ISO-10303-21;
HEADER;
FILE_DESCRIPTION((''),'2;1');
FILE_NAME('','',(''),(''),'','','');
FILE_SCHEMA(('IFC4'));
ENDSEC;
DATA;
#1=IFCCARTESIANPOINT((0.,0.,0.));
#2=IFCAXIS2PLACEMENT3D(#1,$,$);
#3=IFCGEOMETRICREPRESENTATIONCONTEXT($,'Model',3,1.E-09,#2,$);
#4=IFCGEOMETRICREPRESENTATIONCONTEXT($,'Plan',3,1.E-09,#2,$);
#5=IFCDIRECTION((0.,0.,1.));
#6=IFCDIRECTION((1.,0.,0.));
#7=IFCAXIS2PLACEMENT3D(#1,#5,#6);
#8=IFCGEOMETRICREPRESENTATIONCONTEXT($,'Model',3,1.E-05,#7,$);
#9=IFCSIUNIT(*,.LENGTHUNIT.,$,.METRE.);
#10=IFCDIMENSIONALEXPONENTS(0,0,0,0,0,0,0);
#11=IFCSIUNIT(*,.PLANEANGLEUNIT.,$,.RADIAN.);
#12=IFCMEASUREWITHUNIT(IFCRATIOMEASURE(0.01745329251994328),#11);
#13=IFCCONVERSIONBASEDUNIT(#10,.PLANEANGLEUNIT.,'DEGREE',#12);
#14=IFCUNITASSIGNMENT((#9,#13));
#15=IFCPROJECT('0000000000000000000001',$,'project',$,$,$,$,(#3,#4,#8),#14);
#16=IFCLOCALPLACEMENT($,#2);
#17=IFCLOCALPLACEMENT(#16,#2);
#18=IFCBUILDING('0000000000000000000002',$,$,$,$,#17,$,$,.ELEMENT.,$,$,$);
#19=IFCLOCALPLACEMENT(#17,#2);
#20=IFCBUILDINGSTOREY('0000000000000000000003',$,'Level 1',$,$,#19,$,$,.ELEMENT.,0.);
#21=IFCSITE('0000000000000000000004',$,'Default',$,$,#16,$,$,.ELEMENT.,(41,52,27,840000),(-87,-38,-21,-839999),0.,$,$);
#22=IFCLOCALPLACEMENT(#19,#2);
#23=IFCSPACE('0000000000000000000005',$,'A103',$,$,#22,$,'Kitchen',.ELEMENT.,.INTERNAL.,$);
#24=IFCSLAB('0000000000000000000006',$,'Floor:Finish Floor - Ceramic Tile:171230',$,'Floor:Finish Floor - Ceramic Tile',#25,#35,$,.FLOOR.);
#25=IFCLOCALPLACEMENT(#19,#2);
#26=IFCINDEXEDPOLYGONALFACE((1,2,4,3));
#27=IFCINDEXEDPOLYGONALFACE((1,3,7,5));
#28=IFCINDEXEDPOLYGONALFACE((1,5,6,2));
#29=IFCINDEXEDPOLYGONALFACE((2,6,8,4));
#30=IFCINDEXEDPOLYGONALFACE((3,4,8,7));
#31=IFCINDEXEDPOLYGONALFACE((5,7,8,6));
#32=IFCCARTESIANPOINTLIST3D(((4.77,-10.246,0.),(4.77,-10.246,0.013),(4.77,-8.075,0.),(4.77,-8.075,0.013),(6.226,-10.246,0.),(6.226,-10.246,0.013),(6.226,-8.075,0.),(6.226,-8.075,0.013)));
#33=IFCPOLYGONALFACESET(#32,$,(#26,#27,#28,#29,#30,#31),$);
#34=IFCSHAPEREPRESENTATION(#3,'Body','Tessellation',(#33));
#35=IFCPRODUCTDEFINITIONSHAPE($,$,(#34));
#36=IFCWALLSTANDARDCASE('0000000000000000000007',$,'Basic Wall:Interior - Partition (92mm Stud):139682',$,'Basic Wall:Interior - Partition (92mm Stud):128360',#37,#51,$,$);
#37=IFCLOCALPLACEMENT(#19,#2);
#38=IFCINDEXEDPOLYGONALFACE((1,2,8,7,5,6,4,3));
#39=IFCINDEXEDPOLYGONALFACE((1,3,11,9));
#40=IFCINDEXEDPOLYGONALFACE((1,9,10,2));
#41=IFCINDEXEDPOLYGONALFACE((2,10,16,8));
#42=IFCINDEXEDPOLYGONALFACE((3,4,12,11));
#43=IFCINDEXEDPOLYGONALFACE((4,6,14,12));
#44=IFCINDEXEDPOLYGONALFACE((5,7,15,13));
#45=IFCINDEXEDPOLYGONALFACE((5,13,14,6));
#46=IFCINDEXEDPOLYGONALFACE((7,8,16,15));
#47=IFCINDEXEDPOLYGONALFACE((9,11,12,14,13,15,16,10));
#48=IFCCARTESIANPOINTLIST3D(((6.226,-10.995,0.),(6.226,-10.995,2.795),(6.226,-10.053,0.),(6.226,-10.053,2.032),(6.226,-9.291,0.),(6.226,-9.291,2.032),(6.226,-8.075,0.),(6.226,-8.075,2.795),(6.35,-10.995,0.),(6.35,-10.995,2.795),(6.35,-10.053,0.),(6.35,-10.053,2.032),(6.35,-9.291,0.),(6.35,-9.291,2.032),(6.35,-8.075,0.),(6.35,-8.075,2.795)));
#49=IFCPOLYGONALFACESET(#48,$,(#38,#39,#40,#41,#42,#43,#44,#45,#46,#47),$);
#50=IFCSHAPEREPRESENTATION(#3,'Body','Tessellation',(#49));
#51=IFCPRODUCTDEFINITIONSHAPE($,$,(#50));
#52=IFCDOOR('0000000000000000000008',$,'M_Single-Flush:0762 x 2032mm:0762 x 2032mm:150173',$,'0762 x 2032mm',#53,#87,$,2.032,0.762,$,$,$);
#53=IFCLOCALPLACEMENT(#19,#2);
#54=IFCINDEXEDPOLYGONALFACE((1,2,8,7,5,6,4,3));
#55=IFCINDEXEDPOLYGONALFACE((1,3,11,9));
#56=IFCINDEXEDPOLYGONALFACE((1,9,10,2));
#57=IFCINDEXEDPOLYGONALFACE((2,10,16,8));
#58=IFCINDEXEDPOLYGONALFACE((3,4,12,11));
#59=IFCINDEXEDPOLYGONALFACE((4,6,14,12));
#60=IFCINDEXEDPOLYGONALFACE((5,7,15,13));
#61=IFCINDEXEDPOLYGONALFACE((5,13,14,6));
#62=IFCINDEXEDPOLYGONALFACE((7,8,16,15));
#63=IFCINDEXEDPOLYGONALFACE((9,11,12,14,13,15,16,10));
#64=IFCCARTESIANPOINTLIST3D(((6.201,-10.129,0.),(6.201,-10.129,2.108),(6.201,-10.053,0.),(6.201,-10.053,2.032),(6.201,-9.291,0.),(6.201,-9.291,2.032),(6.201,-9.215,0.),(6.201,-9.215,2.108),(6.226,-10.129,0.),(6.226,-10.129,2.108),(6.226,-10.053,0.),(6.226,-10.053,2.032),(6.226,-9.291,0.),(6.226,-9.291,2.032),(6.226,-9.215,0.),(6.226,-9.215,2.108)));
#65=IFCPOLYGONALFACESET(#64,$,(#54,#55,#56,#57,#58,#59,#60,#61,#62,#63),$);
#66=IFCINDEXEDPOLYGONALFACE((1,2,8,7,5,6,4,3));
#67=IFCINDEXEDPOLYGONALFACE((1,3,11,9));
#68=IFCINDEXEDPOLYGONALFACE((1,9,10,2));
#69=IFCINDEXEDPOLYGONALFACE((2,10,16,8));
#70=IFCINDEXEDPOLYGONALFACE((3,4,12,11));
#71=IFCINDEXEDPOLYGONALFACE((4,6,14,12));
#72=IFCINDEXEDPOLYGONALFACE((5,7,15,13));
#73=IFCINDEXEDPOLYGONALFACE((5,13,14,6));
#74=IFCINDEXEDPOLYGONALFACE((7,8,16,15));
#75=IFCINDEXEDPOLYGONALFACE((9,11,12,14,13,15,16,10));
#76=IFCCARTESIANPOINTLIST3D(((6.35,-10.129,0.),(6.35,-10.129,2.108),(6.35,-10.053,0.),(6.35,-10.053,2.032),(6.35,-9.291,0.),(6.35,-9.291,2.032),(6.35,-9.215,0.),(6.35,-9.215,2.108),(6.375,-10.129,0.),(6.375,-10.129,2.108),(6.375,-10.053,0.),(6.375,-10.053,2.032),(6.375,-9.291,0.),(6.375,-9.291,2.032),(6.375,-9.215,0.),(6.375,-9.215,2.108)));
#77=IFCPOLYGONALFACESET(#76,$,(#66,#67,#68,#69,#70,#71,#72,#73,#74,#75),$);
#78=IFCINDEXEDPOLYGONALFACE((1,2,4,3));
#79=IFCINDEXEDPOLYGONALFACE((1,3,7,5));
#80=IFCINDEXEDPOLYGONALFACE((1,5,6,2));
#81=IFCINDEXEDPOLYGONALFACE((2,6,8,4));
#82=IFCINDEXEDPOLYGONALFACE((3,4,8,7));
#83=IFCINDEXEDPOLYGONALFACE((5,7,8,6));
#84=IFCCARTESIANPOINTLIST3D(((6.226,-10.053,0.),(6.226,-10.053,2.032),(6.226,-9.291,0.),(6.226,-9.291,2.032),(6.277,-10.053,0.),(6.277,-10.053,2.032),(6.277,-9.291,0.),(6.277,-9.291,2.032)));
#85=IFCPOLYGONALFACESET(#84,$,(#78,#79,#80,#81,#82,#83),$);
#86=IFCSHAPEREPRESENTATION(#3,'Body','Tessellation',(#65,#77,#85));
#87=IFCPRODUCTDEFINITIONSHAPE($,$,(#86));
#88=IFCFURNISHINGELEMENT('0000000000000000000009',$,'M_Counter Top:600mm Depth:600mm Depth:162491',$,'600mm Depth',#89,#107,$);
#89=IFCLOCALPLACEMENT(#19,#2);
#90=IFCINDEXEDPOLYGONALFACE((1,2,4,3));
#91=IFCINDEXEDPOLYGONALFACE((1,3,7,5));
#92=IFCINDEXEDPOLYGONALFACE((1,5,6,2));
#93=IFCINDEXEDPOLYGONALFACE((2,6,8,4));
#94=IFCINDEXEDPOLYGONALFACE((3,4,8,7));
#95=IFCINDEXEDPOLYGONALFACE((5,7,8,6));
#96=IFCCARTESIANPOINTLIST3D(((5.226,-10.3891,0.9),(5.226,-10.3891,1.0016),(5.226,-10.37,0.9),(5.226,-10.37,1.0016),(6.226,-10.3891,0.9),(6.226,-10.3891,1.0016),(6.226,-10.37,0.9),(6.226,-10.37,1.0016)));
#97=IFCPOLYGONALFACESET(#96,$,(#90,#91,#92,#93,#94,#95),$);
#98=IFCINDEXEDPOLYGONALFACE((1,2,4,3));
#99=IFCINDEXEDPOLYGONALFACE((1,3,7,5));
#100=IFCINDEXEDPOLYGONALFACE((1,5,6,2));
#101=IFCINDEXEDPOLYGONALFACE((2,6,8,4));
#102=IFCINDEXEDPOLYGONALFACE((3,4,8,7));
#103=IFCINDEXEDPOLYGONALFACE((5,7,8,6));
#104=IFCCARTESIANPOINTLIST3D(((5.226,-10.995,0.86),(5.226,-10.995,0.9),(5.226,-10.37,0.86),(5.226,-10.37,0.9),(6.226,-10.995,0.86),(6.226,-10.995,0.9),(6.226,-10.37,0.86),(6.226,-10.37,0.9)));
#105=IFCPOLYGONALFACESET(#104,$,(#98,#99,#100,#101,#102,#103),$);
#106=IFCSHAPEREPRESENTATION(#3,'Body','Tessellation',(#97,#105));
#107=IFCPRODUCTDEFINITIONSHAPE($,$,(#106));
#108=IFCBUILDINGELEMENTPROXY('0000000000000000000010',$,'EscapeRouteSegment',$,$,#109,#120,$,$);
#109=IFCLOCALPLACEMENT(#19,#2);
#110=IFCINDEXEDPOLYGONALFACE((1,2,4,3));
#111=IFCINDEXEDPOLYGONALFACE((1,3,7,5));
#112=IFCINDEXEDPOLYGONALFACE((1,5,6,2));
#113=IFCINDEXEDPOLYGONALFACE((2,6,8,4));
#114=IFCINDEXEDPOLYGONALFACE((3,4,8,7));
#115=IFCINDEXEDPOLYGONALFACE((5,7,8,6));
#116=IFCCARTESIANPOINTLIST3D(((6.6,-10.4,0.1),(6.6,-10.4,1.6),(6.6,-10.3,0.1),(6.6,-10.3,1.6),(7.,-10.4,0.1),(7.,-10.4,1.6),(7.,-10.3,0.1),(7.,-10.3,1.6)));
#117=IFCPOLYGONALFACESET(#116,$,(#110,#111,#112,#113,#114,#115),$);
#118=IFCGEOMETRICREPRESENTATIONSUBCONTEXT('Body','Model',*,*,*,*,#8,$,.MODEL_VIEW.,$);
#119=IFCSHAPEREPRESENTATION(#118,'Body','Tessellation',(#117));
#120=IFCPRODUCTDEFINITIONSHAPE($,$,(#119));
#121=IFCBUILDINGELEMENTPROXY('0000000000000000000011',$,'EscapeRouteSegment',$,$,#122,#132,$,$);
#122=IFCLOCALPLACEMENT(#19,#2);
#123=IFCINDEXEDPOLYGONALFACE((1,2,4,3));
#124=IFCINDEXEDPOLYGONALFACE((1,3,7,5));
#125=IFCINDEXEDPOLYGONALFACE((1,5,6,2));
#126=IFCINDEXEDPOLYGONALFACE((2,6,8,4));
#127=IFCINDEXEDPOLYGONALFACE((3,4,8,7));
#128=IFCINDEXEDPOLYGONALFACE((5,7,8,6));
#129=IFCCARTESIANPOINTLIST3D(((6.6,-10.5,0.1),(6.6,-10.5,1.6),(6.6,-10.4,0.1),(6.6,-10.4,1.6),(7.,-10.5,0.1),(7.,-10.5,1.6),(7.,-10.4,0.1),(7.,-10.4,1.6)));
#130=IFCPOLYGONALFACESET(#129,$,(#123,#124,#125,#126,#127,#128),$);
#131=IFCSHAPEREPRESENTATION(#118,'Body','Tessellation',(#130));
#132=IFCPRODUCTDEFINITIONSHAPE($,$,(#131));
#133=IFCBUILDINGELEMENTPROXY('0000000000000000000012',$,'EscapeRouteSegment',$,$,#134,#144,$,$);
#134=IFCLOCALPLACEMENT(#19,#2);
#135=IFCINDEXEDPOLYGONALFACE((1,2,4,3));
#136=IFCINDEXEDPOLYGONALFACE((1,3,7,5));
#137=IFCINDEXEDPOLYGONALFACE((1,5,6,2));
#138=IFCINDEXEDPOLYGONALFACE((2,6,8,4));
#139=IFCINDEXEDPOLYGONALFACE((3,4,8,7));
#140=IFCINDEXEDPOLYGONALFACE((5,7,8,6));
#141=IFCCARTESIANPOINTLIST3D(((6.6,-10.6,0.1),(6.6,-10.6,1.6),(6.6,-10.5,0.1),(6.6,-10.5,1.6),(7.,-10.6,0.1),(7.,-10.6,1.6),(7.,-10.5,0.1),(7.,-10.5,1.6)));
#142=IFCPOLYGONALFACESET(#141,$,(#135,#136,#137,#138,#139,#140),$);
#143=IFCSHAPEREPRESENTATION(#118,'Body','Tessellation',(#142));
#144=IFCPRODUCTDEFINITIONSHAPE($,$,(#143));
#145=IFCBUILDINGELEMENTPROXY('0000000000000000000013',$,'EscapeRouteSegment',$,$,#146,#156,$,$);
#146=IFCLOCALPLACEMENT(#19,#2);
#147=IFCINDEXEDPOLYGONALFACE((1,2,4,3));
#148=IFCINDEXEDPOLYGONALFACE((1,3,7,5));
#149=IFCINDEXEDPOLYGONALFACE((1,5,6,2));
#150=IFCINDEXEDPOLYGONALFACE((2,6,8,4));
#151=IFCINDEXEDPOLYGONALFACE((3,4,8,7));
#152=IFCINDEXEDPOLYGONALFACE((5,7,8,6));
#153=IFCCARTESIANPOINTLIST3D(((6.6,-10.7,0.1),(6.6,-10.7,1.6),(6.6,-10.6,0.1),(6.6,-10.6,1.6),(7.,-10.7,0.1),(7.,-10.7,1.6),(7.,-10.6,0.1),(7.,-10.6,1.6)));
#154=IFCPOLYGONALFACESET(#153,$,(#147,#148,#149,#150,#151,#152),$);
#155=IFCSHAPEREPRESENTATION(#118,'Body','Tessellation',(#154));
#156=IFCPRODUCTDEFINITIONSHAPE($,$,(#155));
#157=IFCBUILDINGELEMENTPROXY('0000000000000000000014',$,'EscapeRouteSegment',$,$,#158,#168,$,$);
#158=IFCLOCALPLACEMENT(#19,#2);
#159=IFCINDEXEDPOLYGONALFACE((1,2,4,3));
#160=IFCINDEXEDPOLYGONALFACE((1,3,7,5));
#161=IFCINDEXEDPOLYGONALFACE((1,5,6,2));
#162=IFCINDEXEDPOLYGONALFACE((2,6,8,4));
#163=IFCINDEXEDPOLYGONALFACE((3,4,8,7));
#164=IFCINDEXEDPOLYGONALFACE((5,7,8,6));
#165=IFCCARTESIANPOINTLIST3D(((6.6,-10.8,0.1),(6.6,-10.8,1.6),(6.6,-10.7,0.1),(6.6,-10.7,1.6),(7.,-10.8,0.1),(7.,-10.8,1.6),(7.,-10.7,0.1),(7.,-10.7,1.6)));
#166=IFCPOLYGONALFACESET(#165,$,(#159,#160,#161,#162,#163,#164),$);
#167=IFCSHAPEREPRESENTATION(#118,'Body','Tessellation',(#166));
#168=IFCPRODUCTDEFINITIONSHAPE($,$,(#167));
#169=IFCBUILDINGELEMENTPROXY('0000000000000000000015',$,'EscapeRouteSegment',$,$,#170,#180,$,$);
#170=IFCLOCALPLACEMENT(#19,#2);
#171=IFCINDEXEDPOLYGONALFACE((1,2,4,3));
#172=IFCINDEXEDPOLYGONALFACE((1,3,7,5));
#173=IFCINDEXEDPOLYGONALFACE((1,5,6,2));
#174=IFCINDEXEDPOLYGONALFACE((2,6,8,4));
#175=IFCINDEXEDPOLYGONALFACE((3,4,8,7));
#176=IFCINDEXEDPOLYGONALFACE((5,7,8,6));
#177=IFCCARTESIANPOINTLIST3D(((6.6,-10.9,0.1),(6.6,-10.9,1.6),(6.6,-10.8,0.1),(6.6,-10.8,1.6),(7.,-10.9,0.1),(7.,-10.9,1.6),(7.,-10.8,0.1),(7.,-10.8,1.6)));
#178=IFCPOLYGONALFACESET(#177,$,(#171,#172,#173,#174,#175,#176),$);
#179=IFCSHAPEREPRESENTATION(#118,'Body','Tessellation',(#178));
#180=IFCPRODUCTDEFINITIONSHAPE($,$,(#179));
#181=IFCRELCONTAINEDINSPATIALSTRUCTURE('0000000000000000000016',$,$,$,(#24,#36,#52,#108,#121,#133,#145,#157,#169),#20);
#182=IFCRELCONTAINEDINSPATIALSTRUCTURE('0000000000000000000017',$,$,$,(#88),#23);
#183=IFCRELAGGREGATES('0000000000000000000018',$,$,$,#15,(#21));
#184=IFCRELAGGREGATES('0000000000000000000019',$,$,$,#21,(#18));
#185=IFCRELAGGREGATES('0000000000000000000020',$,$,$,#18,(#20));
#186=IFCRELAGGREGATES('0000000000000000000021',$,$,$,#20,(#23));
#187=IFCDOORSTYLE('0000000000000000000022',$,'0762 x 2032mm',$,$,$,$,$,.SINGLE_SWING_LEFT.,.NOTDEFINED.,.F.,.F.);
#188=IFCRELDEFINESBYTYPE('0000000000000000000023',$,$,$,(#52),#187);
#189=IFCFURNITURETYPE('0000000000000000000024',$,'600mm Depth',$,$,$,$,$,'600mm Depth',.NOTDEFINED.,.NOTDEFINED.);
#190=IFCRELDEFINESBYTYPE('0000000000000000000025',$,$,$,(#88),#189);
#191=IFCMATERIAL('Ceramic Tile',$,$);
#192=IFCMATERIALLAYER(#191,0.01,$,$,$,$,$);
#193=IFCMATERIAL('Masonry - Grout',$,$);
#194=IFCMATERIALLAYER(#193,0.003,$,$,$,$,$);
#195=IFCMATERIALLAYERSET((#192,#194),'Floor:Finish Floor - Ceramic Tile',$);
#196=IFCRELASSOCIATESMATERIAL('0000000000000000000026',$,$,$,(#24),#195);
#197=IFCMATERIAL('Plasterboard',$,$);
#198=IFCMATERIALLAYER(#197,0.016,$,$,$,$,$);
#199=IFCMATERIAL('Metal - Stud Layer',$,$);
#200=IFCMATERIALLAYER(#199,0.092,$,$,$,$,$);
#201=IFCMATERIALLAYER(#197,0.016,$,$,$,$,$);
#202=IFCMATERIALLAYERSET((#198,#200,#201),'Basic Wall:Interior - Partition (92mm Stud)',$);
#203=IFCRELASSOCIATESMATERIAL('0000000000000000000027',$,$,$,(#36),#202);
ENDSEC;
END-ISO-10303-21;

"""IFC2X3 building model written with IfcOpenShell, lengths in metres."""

from ifc_helpers import new_model, entity, si_unit, converted_unit, frame, frame_2d, origin, origin_with_axes, origin_2d_with_axis, place, context, subcontext, project, spatial, polyline, rectangle, outline, extrude, source, transform, mapped, material, layer, layer_set, layer_usage, type_object, type_shapes, element, fill, save


model = new_model("IFC2X3")

# Units and contexts
model_context_1 = context("Model", 3, precision=1e-09, world=origin())
plan_context = context("Plan", 3, precision=1e-09, world=origin())
model_context_2 = context("Model", 3, precision=1e-05, world=origin_with_axes())
body_context = subcontext(model_context_2, "Body", "Model", "MODEL_VIEW")
ifc_project = project(units=[si_unit("LENGTHUNIT", "METRE"), converted_unit("PLANEANGLEUNIT", "DEGREE", entity("IfcRatioMeasure", 0.01745329251994328), si_unit("PLANEANGLEUNIT", "RADIAN"), dimensions=[0, 0, 0, 0, 0, 0, 0])], contexts=[model_context_1, plan_context, model_context_2])

# Site, building, storey
site_placement = place(None, origin())
site = spatial("IfcSite", under=ifc_project, at=site_placement, Name="Default", CompositionType="ELEMENT", RefLatitude=(41, 52, 27, 840000), RefLongitude=(-87, -38, -21, -839999), RefElevation=0.0)
building_placement = place(site_placement, origin())
building = spatial("IfcBuilding", under=site, at=building_placement, CompositionType="ELEMENT")
storey_placement = place(building_placement, origin())
storey = spatial("IfcBuildingStorey", under=building, at=storey_placement, Name="Level 1", CompositionType="ELEMENT", Elevation=0.0)

# Slab
ifc_material_1 = material(Name="Ceramic Tile")
ifc_layer_1 = layer(ifc_material_1, 0.01)
ifc_material_2 = material(Name="Masonry - Grout")
ifc_layer_2 = layer(ifc_material_2, 0.003)
ifc_layer_set_1 = layer_set([ifc_layer_1, ifc_layer_2], Name="Floor:Finish Floor - Ceramic Tile")
ifc_layer_usage_1 = layer_usage(ifc_layer_set_1, "AXIS3", "POSITIVE", 0.0)
slab_placement = place(storey_placement, frame((4.77, -10.246, 0.0)))
element("IfcSlab", 1, at=slab_placement, inside=storey, material=ifc_layer_usage_1, Name="Floor:Finish Floor - Ceramic Tile:171230", ObjectType="Floor:Finish Floor - Ceramic Tile", PredefinedType="FLOOR", context=model_context_1, shape_type="SweptSolid", body=[
    extrude(rectangle(XDim=1.456, YDim=2.171, at=frame_2d((0.0, 0.0), x_axis=(-1.0, 0.0))), frame((0.728, 1.0855, 0.013), z_axis=(0.0, 0.0, -1.0), x_axis=(-1.0, 0.0, 0.0)), (0.0, 0.0, 1.0), 0.013),
])

# Wall, opening, door
ifc_material_3 = material(Name="Plasterboard")
ifc_layer_3 = layer(ifc_material_3, 0.016)
ifc_material_4 = material(Name="Metal - Stud Layer")
ifc_layer_4 = layer(ifc_material_4, 0.092)
ifc_layer_5 = layer(ifc_material_3, 0.016)
ifc_layer_set_2 = layer_set([ifc_layer_3, ifc_layer_4, ifc_layer_5], Name="Basic Wall:Interior - Partition (92mm Stud)")
ifc_layer_usage_2 = layer_usage(ifc_layer_set_2, "AXIS2", "NEGATIVE", 0.062)
wall_placement = place(storey_placement, frame((6.288, -10.995, 0.0), z_axis=(0.0, 0.0, 1.0), x_axis=(0.0, 1.0, 0.0)))
wall = element("IfcWallStandardCase", 2, at=wall_placement, inside=storey, material=ifc_layer_usage_2, Name="Basic Wall:Interior - Partition (92mm Stud):139682", ObjectType="Basic Wall:Interior - Partition (92mm Stud):128360", context=model_context_1, shape_type="SweptSolid", body=[
    extrude(rectangle(XDim=2.92, YDim=0.124, at=frame_2d((1.46, 0.0), x_axis=(-1.0, 0.0))), origin(), (0.0, 0.0, 1.0), 2.795),
])
opening_placement = place(wall_placement, frame((0.942, -0.062, 0.0)))
opening = element("IfcOpeningElement", 3, at=opening_placement, cuts=wall, ObjectType="Opening", context=model_context_1, shape_type="SweptSolid", body=[
    extrude(rectangle(XDim=0.762, YDim=2.032, at=frame_2d((1.016, 0.381), x_axis=(0.0, -1.0))), frame((0.0, 0.0, 0.0), z_axis=(0.0, 1.0, 0.0), x_axis=(0.0, 0.0, 1.0)), (0.0, 0.0, 1.0), 0.124),
])
door_style = type_object("IfcDoorStyle", Name="0762 x 2032mm", ConstructionType="NOTDEFINED", OperationType="SINGLE_SWING_LEFT", ParameterTakesPrecedence=False, Sizeable=False)
shared_shape_1 = source(origin(), model_context_1, "Body", "SweptSolid", [
    extrude(outline(polyline([(-0.457, -1.073), (0.457, -1.073), (0.457, 1.035), (0.381, 1.035), (0.381, -0.997), (-0.381, -0.997), (-0.381, 1.035), (-0.457, 1.035), (-0.457, -1.073)])), frame((0.381, 0.149, 1.035), z_axis=(0.0, -1.0, 0.0), x_axis=(-1.0, 0.0, 0.0)), (0.0, 0.0, 1.0), 0.025),
    extrude(outline(polyline([(-1.073, -0.457), (1.035, -0.457), (1.035, -0.381), (-0.997, -0.381), (-0.997, 0.381), (1.035, 0.381), (1.035, 0.457), (-1.073, 0.457), (-1.073, -0.457)])), frame((0.381, 0.0, 1.035), z_axis=(0.0, -1.0, 0.0), x_axis=(0.0, 0.0, -1.0)), (0.0, 0.0, 1.0), 0.025),
    extrude(rectangle(XDim=0.762, YDim=0.051, at=origin_2d_with_axis()), frame((0.381, 0.0985, 0.0)), (0.0, 0.0, 1.0), 2.032),
])
type_shapes(door_style, [shared_shape_1])
door_placement = place(opening_placement, origin())
door = element("IfcDoor", 4, at=door_placement, inside=storey, type_object=door_style, Name="M_Single-Flush:0762 x 2032mm:0762 x 2032mm:150173", ObjectType="0762 x 2032mm", OverallHeight=2.032, OverallWidth=0.762, context=model_context_1, shape_type="MappedRepresentation", body=[
    mapped(shared_shape_1, transform((0.0, 0.0, 0.0), scale=1.0)),
])
fill(opening, door)

# Shared definitions
space_placement = place(storey_placement, origin())
space = spatial("IfcSpace", under=storey, at=space_placement, Name="A103", LongName="Kitchen", CompositionType="ELEMENT", InteriorOrExteriorSpace="INTERNAL")

# Furnishing element
furniture_type = type_object("IfcFurnitureType", Name="600mm Depth", ElementType="600mm Depth", AssemblyPlace="NOTDEFINED")
shared_shape_2 = source(origin(), model_context_1, "Body", "SweptSolid", [
    extrude(rectangle(XDim=0.0191, YDim=1.0, at=origin_2d_with_axis()), frame((-0.7005, -0.0095, 0.9), z_axis=(0.0, 0.0, 1.0), x_axis=(0.0, -1.0, 0.0)), (0.0, 0.0, 1.0), 0.1016),
    extrude(rectangle(XDim=1.0, YDim=0.625, at=origin_2d_with_axis()), frame((-0.7005, -0.3125, 0.86), z_axis=(0.0, 0.0, 1.0), x_axis=(-1.0, 0.0, 0.0)), (0.0, 0.0, 1.0), 0.04),
])
type_shapes(furniture_type, [shared_shape_2])
furnishing_placement = place(space_placement, frame((6.4265, -10.37, 0.0)))
element("IfcFurnishingElement", 5, at=furnishing_placement, inside=space, type_object=furniture_type, Name="M_Counter Top:600mm Depth:600mm Depth:162491", ObjectType="600mm Depth", context=model_context_1, shape_type="MappedRepresentation", body=[
    mapped(shared_shape_2, transform((0.0, 0.0, 0.0), scale=1.0)),
])

# Building element proxies
proxy_1_placement = place(storey_placement, frame((6.8, -10.3, 0.1), z_axis=(0.0, 0.0, 1.0), x_axis=(0.0, -1.0, 0.0)))
element("IfcBuildingElementProxy", 6, at=proxy_1_placement, inside=storey, Name="EscapeRouteSegment", context=body_context, shape_type="SweptSolid", body=[
    extrude(outline(polyline([(0.0, -0.2), (0.0, 0.2), (0.1, 0.2), (0.1, -0.2), (0.0, -0.2)])), origin_with_axes(), (0.0, 0.0, 1.0), 1.5),
])
for number, where, z_axis, x_axis, name in (
    (7, (6.8, -10.4, 0.1), (0.0, 0.0, 1.0), (0.0, -1.0, 0.0), "EscapeRouteSegment"),
    (8, (6.8, -10.5, 0.1), (0.0, 0.0, 1.0), (0.0, -1.0, 0.0), "EscapeRouteSegment"),
):
    element("IfcBuildingElementProxy", number, at=place(storey_placement, frame(where, z_axis=z_axis, x_axis=x_axis)), inside=storey, Name=name, context=body_context, shape_type="SweptSolid", body=[
        extrude(outline(polyline([(0.0, -0.2), (0.0, 0.2), (0.1, 0.2), (0.1, -0.2), (0.0, -0.2)])), origin_with_axes(), (0.0, 0.0, 1.0), 1.5),
    ])
proxy_2_placement = place(storey_placement, frame((6.8, -10.6, 0.1), z_axis=(0.0, 0.0, 1.0), x_axis=(0.0, -1.0, 0.0)))
element("IfcBuildingElementProxy", 9, at=proxy_2_placement, inside=storey, Name="EscapeRouteSegment", context=body_context, shape_type="SweptSolid", body=[
    extrude(outline(polyline([(0.0, -0.2), (0.0, 0.2), (0.1, 0.2), (0.1, -0.2), (0.0, -0.2)])), origin_with_axes(), (0.0, 0.0, 1.0), 1.5),
])
proxy_3_placement = place(storey_placement, frame((6.8, -10.7, 0.1), z_axis=(0.0, 0.0, 1.0), x_axis=(0.0, -1.0, 0.0)))
element("IfcBuildingElementProxy", 10, at=proxy_3_placement, inside=storey, Name="EscapeRouteSegment", context=body_context, shape_type="SweptSolid", body=[
    extrude(outline(polyline([(0.0, -0.2), (0.0, 0.2), (0.1, 0.2), (0.1, -0.2), (0.0, -0.2)])), origin_with_axes(), (0.0, 0.0, 1.0), 1.5),
])
proxy_4_placement = place(storey_placement, frame((6.8, -10.8, 0.1), z_axis=(0.0, 0.0, 1.0), x_axis=(0.0, -1.0, 0.0)))
element("IfcBuildingElementProxy", 11, at=proxy_4_placement, inside=storey, Name="EscapeRouteSegment", context=body_context, shape_type="SweptSolid", body=[
    extrude(outline(polyline([(0.0, -0.2), (0.0, 0.2), (0.1, 0.2), (0.1, -0.2), (0.0, -0.2)])), origin_with_axes(), (0.0, 0.0, 1.0), 1.5),
])

save(model, "model.ifc")
